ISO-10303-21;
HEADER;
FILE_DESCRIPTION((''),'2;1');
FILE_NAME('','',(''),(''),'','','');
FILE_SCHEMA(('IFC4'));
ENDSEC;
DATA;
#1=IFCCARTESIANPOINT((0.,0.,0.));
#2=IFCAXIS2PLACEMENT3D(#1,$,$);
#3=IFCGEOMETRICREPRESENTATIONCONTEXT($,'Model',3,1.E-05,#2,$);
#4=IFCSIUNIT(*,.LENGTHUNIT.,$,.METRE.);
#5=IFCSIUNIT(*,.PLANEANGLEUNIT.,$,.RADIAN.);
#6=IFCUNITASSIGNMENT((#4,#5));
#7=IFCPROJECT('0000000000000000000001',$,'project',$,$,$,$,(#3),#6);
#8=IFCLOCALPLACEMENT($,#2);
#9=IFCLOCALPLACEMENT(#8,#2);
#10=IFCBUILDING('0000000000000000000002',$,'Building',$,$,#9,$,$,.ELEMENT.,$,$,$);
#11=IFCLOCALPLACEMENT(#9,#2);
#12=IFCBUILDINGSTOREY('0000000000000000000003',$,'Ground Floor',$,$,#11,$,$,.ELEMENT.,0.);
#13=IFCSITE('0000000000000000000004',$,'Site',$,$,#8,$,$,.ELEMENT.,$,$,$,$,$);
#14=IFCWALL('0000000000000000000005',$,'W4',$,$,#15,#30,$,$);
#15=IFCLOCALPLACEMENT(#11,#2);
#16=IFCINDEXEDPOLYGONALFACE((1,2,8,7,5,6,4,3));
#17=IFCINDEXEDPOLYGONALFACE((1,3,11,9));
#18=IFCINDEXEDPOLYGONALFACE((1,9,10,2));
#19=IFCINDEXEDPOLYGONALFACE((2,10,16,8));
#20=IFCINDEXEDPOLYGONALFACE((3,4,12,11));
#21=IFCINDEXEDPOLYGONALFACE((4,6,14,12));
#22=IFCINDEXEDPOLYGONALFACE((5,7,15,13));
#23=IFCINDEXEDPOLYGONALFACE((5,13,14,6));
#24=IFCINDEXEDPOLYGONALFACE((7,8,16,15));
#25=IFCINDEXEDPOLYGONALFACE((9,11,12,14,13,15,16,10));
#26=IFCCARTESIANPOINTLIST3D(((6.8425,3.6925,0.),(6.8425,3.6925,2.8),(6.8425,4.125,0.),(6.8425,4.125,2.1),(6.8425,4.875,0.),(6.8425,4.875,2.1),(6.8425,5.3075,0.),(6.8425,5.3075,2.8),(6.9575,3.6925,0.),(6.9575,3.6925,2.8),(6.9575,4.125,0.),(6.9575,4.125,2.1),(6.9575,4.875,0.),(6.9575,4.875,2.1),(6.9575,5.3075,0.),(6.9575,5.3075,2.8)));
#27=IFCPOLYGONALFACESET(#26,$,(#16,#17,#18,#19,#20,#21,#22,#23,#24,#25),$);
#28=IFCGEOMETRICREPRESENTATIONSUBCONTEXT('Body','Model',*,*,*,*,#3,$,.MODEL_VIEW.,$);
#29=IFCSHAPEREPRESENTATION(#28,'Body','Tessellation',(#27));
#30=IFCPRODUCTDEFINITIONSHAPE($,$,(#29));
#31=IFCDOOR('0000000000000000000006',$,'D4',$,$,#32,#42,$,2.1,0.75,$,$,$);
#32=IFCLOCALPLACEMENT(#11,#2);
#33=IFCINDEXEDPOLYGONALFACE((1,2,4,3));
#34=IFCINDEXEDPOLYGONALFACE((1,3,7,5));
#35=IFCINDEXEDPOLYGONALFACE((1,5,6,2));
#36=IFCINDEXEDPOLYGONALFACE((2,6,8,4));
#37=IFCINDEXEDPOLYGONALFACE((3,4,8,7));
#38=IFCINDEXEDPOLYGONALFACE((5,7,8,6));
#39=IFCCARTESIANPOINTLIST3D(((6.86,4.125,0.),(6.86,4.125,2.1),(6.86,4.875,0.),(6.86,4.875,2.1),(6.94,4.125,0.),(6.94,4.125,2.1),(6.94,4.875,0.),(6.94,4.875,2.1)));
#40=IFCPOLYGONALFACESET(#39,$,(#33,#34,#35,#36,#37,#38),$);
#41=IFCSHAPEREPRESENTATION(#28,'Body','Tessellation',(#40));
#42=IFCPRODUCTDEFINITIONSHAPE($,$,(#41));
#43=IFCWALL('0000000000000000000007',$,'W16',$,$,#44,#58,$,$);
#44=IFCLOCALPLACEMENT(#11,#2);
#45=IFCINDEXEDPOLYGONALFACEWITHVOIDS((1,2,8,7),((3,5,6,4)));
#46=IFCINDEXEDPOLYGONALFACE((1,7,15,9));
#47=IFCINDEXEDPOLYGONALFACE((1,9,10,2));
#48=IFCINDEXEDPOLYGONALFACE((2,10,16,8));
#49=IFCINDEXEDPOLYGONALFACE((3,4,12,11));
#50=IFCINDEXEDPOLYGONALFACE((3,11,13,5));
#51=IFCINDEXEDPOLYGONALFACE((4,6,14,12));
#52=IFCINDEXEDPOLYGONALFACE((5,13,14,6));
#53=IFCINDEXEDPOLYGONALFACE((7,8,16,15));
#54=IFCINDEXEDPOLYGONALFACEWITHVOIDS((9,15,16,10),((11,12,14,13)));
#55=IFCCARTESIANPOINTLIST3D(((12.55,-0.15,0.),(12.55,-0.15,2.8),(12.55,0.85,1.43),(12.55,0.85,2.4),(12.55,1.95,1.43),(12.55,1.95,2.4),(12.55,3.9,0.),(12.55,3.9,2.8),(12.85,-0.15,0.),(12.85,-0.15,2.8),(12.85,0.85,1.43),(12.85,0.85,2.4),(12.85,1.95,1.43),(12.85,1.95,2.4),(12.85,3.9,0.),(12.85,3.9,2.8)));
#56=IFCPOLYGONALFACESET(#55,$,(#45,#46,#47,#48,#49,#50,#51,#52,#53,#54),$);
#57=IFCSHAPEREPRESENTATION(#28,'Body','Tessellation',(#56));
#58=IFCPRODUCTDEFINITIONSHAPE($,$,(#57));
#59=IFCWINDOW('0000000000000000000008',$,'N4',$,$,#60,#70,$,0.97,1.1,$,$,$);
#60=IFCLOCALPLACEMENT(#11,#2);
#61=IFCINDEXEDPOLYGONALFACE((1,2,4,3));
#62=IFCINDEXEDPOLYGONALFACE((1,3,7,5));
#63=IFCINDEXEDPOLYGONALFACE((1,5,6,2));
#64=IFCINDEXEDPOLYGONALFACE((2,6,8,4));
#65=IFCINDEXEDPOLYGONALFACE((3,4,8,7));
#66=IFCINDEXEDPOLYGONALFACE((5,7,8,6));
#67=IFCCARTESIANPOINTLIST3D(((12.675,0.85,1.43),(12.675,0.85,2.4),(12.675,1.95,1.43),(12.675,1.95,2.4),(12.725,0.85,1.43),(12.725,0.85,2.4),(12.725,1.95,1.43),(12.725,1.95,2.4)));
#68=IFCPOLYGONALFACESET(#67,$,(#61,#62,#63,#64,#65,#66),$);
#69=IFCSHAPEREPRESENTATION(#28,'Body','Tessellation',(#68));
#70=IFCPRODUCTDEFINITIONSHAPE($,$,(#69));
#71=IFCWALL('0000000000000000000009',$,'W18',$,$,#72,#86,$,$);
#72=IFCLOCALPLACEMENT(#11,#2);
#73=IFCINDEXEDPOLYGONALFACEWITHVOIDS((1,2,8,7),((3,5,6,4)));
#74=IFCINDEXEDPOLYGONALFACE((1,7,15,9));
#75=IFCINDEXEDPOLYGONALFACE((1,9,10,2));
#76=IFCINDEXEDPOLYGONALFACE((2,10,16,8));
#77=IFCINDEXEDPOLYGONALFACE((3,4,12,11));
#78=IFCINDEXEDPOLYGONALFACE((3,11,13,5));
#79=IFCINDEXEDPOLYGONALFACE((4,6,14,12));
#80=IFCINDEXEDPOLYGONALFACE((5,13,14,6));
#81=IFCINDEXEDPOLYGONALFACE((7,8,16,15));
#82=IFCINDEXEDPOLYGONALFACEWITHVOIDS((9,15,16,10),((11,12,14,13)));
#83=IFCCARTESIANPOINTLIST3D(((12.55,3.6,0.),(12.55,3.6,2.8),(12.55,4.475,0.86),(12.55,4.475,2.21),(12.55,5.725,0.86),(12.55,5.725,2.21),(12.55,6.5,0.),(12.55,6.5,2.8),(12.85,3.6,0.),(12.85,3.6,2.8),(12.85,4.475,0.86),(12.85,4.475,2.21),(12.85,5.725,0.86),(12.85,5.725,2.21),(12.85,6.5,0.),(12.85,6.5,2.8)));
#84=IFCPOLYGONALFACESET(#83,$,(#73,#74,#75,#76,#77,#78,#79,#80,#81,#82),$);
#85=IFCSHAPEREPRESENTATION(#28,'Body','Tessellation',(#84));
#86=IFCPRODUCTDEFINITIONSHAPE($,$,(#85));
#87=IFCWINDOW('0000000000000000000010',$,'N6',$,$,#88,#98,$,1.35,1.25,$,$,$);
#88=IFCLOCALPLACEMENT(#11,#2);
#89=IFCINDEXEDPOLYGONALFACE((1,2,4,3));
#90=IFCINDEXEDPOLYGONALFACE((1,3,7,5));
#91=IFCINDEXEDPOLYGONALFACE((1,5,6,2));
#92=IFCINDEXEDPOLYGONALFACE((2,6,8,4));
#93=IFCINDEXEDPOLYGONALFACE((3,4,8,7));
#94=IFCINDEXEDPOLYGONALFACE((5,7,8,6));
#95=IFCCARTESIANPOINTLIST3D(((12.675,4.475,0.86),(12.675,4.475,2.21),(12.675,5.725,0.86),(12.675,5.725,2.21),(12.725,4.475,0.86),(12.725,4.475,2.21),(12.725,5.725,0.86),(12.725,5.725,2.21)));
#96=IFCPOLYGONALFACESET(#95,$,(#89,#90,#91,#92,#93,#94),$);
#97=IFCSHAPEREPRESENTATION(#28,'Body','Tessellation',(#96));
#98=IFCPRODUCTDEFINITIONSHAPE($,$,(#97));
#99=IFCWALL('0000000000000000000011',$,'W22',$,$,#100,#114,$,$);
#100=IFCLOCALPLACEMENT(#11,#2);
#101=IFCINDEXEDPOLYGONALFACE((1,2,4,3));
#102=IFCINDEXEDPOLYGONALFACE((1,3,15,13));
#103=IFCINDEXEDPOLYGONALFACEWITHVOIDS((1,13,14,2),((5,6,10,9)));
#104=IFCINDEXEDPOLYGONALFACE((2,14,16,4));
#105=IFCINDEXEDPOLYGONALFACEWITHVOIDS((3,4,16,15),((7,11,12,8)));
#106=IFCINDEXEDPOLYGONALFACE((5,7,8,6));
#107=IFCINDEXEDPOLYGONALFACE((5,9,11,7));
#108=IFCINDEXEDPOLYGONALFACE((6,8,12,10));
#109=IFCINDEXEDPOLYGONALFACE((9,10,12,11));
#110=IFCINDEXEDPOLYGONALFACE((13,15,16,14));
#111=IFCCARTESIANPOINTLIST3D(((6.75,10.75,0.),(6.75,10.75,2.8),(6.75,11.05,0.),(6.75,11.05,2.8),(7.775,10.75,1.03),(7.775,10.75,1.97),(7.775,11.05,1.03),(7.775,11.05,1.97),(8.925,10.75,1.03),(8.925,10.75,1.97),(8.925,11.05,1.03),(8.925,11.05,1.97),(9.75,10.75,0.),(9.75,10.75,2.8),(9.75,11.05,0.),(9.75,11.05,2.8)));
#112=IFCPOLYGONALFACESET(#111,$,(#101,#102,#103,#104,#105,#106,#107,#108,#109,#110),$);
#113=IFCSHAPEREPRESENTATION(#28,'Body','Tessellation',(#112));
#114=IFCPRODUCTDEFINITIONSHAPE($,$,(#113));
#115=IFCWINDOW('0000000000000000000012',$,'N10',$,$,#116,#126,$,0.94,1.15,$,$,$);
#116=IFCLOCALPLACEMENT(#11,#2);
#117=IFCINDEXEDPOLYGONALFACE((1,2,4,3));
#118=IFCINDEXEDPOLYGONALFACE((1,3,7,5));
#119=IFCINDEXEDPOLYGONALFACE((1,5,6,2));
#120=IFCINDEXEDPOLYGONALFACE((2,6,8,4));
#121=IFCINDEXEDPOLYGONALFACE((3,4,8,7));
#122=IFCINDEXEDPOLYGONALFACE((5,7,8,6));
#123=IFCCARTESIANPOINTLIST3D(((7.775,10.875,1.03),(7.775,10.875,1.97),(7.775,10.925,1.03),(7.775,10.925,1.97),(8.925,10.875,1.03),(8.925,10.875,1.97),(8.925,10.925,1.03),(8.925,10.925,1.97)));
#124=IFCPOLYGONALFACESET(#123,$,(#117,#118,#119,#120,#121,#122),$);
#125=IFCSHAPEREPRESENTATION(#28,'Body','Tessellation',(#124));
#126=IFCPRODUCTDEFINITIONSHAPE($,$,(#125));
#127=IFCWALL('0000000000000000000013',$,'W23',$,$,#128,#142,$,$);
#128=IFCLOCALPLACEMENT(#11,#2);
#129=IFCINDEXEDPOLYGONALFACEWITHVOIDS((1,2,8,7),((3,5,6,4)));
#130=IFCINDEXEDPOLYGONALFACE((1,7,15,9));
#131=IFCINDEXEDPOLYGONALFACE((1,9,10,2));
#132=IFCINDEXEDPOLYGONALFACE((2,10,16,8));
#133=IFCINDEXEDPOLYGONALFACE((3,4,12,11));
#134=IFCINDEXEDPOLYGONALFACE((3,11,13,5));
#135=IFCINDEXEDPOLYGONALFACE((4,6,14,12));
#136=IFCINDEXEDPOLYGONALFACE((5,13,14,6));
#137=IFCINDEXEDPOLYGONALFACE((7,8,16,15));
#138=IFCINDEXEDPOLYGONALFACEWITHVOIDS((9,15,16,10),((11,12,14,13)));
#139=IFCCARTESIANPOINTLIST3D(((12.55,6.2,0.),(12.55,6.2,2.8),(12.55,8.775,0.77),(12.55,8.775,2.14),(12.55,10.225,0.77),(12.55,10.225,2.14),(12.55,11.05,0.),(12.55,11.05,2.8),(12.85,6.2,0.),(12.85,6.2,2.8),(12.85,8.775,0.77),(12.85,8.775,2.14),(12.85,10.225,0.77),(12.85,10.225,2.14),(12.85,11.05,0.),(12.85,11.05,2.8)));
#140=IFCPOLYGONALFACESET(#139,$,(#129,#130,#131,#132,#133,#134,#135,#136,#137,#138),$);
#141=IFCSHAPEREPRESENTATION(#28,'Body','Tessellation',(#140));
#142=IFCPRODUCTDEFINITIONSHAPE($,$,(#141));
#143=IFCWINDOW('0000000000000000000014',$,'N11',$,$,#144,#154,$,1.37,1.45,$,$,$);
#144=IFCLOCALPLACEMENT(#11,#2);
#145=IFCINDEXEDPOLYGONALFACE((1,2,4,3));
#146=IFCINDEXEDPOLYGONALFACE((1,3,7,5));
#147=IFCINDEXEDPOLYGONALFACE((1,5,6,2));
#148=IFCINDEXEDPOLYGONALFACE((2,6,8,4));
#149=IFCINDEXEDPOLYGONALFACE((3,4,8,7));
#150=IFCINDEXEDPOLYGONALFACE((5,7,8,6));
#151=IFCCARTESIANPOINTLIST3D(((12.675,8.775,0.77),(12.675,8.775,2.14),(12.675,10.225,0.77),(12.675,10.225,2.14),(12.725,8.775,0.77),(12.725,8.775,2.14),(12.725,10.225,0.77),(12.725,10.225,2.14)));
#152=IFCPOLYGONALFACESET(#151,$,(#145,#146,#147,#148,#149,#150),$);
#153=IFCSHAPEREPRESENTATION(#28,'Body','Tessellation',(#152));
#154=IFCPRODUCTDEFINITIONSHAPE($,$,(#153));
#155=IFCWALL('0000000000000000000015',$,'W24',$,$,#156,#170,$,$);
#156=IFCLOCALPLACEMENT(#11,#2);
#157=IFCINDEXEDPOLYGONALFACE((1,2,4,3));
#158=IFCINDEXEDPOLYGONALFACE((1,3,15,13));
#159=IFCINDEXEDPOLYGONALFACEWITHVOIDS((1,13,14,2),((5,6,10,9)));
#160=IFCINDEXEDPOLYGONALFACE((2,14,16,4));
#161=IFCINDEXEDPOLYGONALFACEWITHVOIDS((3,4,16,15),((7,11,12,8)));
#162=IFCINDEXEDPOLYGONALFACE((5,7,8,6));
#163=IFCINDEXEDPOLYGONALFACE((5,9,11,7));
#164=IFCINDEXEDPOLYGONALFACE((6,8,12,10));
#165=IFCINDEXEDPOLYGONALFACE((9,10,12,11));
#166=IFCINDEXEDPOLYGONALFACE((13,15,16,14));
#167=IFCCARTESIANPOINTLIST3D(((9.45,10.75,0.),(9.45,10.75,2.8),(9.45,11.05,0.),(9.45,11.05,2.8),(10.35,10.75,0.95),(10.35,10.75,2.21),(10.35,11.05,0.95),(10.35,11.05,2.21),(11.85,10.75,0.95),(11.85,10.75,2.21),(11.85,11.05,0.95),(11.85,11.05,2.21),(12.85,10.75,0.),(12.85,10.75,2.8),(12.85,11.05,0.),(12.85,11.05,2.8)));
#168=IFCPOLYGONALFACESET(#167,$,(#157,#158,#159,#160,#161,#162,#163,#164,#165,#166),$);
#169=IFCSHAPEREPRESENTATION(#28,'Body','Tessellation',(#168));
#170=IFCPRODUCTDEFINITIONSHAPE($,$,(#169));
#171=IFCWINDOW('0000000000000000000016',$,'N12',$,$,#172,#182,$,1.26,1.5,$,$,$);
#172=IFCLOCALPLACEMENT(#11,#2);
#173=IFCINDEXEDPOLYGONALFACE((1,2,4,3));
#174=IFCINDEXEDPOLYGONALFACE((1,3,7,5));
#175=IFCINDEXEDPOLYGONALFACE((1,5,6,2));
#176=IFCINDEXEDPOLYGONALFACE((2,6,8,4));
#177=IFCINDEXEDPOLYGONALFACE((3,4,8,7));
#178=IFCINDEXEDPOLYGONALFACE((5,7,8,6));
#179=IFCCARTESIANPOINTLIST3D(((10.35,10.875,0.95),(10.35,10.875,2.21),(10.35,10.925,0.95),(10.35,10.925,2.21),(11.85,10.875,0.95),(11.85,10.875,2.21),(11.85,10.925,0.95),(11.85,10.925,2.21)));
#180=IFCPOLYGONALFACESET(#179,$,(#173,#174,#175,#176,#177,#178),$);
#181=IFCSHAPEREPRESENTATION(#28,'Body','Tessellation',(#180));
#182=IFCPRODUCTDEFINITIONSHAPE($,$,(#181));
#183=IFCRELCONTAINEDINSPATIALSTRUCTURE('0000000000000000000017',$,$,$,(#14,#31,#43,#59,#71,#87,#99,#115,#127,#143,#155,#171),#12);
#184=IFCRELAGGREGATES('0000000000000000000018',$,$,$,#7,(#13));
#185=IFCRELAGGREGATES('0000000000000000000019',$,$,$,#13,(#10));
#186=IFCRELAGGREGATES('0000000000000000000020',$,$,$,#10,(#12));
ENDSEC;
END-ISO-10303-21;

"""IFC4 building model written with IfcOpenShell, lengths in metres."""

from ifc_helpers import new_model, si_unit, frame, frame_2d, origin, origin_2d, place, context, subcontext, project, spatial, rectangle, extrude, element, fill, save


model = new_model("IFC4")

# Units and contexts
model_context = context("Model", 3, precision=1e-05, world=origin())
body_context = subcontext(model_context, "Body", "Model", "MODEL_VIEW")
ifc_project = project(units=[si_unit("LENGTHUNIT", "METRE"), si_unit("PLANEANGLEUNIT", "RADIAN")], contexts=[model_context])

# Site, building, storey
site_placement = place(None, origin())
site = spatial("IfcSite", under=ifc_project, at=site_placement, Name="Site", CompositionType="ELEMENT")
building_placement = place(site_placement, origin())
building = spatial("IfcBuilding", under=site, at=building_placement, Name="Building", CompositionType="ELEMENT")
storey_placement = place(building_placement, origin())
storey = spatial("IfcBuildingStorey", under=building, at=storey_placement, Name="Ground Floor", CompositionType="ELEMENT", Elevation=0.0)

# Wall, opening, door
wall_1_placement = place(storey_placement, frame((6.9, 3.75, 0.0), x_axis=(0.0, 1.0, 0.0)))
wall_1 = element("IfcWall", 1, at=wall_1_placement, inside=storey, Name="W4", context=body_context, shape_type="SweptSolid", body=[
    extrude(rectangle(XDim=1.615, YDim=0.115, at=frame_2d((0.75, 0.0))), origin(), (0.0, 0.0, 1.0), 2.8),
])
opening_1_placement = place(wall_1_placement, frame((0.75, 0.0, 0.0)))
opening_1 = element("IfcOpeningElement", 2, at=opening_1_placement, cuts=wall_1, context=body_context, shape_type="SweptSolid", body=[
    extrude(rectangle(XDim=0.75, YDim=0.215, at=origin_2d()), origin(), (0.0, 0.0, 1.0), 2.1),
])
door_1_placement = place(opening_1_placement, origin())
door_1 = element("IfcDoor", 3, at=door_1_placement, inside=storey, Name="D4", OverallHeight=2.1, OverallWidth=0.75, context=body_context, shape_type="SweptSolid", body=[
    extrude(rectangle(XDim=0.75, YDim=0.08, at=origin_2d()), origin(), (0.0, 0.0, 1.0), 2.1),
])
fill(opening_1, door_1)

# Walls, openings, windows
wall_2_placement = place(storey_placement, frame((12.7, 0.0, 0.0), x_axis=(0.0, 1.0, 0.0)))
wall_2 = element("IfcWall", 4, at=wall_2_placement, inside=storey, Name="W16", context=body_context, shape_type="SweptSolid", body=[
    extrude(rectangle(XDim=4.05, YDim=0.3, at=frame_2d((1.875, 0.0))), origin(), (0.0, 0.0, 1.0), 2.8),
])
opening_2_placement = place(wall_2_placement, frame((1.4, 0.0, 1.43)))
opening_2 = element("IfcOpeningElement", 5, at=opening_2_placement, cuts=wall_2, context=body_context, shape_type="SweptSolid", body=[
    extrude(rectangle(XDim=1.1, YDim=0.4, at=origin_2d()), origin(), (0.0, 0.0, 1.0), 0.97),
])
window_1_placement = place(opening_2_placement, origin())
window_1 = element("IfcWindow", 6, at=window_1_placement, inside=storey, Name="N4", OverallHeight=0.97, OverallWidth=1.1, context=body_context, shape_type="SweptSolid", body=[
    extrude(rectangle(XDim=1.1, YDim=0.05, at=origin_2d()), origin(), (0.0, 0.0, 1.0), 0.97),
])
fill(opening_2, window_1)
wall_3_placement = place(storey_placement, frame((12.7, 3.75, 0.0), x_axis=(0.0, 1.0, 0.0)))
wall_3 = element("IfcWall", 7, at=wall_3_placement, inside=storey, Name="W18", context=body_context, shape_type="SweptSolid", body=[
    extrude(rectangle(XDim=2.9, YDim=0.3, at=frame_2d((1.3, 0.0))), origin(), (0.0, 0.0, 1.0), 2.8),
])
opening_3_placement = place(wall_3_placement, frame((1.35, 0.0, 0.86)))
opening_3 = element("IfcOpeningElement", 8, at=opening_3_placement, cuts=wall_3, context=body_context, shape_type="SweptSolid", body=[
    extrude(rectangle(XDim=1.25, YDim=0.4, at=origin_2d()), origin(), (0.0, 0.0, 1.0), 1.35),
])
window_2_placement = place(opening_3_placement, origin())
window_2 = element("IfcWindow", 9, at=window_2_placement, inside=storey, Name="N6", OverallHeight=1.35, OverallWidth=1.25, context=body_context, shape_type="SweptSolid", body=[
    extrude(rectangle(XDim=1.25, YDim=0.05, at=origin_2d()), origin(), (0.0, 0.0, 1.0), 1.35),
])
fill(opening_3, window_2)
wall_4_placement = place(storey_placement, frame((6.9, 10.9, 0.0), x_axis=(1.0, 0.0, 0.0)))
wall_4 = element("IfcWall", 10, at=wall_4_placement, inside=storey, Name="W22", context=body_context, shape_type="SweptSolid", body=[
    extrude(rectangle(XDim=3.0, YDim=0.3, at=frame_2d((1.35, 0.0))), origin(), (0.0, 0.0, 1.0), 2.8),
])
opening_4_placement = place(wall_4_placement, frame((1.45, 0.0, 1.03)))
opening_4 = element("IfcOpeningElement", 11, at=opening_4_placement, cuts=wall_4, context=body_context, shape_type="SweptSolid", body=[
    extrude(rectangle(XDim=1.15, YDim=0.4, at=origin_2d()), origin(), (0.0, 0.0, 1.0), 0.94),
])
window_3_placement = place(opening_4_placement, origin())
window_3 = element("IfcWindow", 12, at=window_3_placement, inside=storey, Name="N10", OverallHeight=0.94, OverallWidth=1.15, context=body_context, shape_type="SweptSolid", body=[
    extrude(rectangle(XDim=1.15, YDim=0.05, at=origin_2d()), origin(), (0.0, 0.0, 1.0), 0.94),
])
fill(opening_4, window_3)
wall_5_placement = place(storey_placement, frame((12.7, 6.35, 0.0), x_axis=(0.0, 1.0, 0.0)))
wall_5 = element("IfcWall", 13, at=wall_5_placement, inside=storey, Name="W23", context=body_context, shape_type="SweptSolid", body=[
    extrude(rectangle(XDim=4.85, YDim=0.3, at=frame_2d((2.275, 0.0))), origin(), (0.0, 0.0, 1.0), 2.8),
])
opening_5_placement = place(wall_5_placement, frame((3.15, 0.0, 0.77)))
opening_5 = element("IfcOpeningElement", 14, at=opening_5_placement, cuts=wall_5, context=body_context, shape_type="SweptSolid", body=[
    extrude(rectangle(XDim=1.45, YDim=0.4, at=origin_2d()), origin(), (0.0, 0.0, 1.0), 1.37),
])
window_4_placement = place(opening_5_placement, origin())
window_4 = element("IfcWindow", 15, at=window_4_placement, inside=storey, Name="N11", OverallHeight=1.37, OverallWidth=1.45, context=body_context, shape_type="SweptSolid", body=[
    extrude(rectangle(XDim=1.45, YDim=0.05, at=origin_2d()), origin(), (0.0, 0.0, 1.0), 1.37),
])
fill(opening_5, window_4)
wall_6_placement = place(storey_placement, frame((9.6, 10.9, 0.0), x_axis=(1.0, 0.0, 0.0)))
wall_6 = element("IfcWall", 16, at=wall_6_placement, inside=storey, Name="W24", context=body_context, shape_type="SweptSolid", body=[
    extrude(rectangle(XDim=3.4, YDim=0.3, at=frame_2d((1.55, 0.0))), origin(), (0.0, 0.0, 1.0), 2.8),
])
opening_6_placement = place(wall_6_placement, frame((1.5, 0.0, 0.95)))
opening_6 = element("IfcOpeningElement", 17, at=opening_6_placement, cuts=wall_6, context=body_context, shape_type="SweptSolid", body=[
    extrude(rectangle(XDim=1.5, YDim=0.4, at=origin_2d()), origin(), (0.0, 0.0, 1.0), 1.26),
])
window_5_placement = place(opening_6_placement, origin())
window_5 = element("IfcWindow", 18, at=window_5_placement, inside=storey, Name="N12", OverallHeight=1.26, OverallWidth=1.5, context=body_context, shape_type="SweptSolid", body=[
    extrude(rectangle(XDim=1.5, YDim=0.05, at=origin_2d()), origin(), (0.0, 0.0, 1.0), 1.26),
])
fill(opening_6, window_5)

save(model, "model.ifc")
